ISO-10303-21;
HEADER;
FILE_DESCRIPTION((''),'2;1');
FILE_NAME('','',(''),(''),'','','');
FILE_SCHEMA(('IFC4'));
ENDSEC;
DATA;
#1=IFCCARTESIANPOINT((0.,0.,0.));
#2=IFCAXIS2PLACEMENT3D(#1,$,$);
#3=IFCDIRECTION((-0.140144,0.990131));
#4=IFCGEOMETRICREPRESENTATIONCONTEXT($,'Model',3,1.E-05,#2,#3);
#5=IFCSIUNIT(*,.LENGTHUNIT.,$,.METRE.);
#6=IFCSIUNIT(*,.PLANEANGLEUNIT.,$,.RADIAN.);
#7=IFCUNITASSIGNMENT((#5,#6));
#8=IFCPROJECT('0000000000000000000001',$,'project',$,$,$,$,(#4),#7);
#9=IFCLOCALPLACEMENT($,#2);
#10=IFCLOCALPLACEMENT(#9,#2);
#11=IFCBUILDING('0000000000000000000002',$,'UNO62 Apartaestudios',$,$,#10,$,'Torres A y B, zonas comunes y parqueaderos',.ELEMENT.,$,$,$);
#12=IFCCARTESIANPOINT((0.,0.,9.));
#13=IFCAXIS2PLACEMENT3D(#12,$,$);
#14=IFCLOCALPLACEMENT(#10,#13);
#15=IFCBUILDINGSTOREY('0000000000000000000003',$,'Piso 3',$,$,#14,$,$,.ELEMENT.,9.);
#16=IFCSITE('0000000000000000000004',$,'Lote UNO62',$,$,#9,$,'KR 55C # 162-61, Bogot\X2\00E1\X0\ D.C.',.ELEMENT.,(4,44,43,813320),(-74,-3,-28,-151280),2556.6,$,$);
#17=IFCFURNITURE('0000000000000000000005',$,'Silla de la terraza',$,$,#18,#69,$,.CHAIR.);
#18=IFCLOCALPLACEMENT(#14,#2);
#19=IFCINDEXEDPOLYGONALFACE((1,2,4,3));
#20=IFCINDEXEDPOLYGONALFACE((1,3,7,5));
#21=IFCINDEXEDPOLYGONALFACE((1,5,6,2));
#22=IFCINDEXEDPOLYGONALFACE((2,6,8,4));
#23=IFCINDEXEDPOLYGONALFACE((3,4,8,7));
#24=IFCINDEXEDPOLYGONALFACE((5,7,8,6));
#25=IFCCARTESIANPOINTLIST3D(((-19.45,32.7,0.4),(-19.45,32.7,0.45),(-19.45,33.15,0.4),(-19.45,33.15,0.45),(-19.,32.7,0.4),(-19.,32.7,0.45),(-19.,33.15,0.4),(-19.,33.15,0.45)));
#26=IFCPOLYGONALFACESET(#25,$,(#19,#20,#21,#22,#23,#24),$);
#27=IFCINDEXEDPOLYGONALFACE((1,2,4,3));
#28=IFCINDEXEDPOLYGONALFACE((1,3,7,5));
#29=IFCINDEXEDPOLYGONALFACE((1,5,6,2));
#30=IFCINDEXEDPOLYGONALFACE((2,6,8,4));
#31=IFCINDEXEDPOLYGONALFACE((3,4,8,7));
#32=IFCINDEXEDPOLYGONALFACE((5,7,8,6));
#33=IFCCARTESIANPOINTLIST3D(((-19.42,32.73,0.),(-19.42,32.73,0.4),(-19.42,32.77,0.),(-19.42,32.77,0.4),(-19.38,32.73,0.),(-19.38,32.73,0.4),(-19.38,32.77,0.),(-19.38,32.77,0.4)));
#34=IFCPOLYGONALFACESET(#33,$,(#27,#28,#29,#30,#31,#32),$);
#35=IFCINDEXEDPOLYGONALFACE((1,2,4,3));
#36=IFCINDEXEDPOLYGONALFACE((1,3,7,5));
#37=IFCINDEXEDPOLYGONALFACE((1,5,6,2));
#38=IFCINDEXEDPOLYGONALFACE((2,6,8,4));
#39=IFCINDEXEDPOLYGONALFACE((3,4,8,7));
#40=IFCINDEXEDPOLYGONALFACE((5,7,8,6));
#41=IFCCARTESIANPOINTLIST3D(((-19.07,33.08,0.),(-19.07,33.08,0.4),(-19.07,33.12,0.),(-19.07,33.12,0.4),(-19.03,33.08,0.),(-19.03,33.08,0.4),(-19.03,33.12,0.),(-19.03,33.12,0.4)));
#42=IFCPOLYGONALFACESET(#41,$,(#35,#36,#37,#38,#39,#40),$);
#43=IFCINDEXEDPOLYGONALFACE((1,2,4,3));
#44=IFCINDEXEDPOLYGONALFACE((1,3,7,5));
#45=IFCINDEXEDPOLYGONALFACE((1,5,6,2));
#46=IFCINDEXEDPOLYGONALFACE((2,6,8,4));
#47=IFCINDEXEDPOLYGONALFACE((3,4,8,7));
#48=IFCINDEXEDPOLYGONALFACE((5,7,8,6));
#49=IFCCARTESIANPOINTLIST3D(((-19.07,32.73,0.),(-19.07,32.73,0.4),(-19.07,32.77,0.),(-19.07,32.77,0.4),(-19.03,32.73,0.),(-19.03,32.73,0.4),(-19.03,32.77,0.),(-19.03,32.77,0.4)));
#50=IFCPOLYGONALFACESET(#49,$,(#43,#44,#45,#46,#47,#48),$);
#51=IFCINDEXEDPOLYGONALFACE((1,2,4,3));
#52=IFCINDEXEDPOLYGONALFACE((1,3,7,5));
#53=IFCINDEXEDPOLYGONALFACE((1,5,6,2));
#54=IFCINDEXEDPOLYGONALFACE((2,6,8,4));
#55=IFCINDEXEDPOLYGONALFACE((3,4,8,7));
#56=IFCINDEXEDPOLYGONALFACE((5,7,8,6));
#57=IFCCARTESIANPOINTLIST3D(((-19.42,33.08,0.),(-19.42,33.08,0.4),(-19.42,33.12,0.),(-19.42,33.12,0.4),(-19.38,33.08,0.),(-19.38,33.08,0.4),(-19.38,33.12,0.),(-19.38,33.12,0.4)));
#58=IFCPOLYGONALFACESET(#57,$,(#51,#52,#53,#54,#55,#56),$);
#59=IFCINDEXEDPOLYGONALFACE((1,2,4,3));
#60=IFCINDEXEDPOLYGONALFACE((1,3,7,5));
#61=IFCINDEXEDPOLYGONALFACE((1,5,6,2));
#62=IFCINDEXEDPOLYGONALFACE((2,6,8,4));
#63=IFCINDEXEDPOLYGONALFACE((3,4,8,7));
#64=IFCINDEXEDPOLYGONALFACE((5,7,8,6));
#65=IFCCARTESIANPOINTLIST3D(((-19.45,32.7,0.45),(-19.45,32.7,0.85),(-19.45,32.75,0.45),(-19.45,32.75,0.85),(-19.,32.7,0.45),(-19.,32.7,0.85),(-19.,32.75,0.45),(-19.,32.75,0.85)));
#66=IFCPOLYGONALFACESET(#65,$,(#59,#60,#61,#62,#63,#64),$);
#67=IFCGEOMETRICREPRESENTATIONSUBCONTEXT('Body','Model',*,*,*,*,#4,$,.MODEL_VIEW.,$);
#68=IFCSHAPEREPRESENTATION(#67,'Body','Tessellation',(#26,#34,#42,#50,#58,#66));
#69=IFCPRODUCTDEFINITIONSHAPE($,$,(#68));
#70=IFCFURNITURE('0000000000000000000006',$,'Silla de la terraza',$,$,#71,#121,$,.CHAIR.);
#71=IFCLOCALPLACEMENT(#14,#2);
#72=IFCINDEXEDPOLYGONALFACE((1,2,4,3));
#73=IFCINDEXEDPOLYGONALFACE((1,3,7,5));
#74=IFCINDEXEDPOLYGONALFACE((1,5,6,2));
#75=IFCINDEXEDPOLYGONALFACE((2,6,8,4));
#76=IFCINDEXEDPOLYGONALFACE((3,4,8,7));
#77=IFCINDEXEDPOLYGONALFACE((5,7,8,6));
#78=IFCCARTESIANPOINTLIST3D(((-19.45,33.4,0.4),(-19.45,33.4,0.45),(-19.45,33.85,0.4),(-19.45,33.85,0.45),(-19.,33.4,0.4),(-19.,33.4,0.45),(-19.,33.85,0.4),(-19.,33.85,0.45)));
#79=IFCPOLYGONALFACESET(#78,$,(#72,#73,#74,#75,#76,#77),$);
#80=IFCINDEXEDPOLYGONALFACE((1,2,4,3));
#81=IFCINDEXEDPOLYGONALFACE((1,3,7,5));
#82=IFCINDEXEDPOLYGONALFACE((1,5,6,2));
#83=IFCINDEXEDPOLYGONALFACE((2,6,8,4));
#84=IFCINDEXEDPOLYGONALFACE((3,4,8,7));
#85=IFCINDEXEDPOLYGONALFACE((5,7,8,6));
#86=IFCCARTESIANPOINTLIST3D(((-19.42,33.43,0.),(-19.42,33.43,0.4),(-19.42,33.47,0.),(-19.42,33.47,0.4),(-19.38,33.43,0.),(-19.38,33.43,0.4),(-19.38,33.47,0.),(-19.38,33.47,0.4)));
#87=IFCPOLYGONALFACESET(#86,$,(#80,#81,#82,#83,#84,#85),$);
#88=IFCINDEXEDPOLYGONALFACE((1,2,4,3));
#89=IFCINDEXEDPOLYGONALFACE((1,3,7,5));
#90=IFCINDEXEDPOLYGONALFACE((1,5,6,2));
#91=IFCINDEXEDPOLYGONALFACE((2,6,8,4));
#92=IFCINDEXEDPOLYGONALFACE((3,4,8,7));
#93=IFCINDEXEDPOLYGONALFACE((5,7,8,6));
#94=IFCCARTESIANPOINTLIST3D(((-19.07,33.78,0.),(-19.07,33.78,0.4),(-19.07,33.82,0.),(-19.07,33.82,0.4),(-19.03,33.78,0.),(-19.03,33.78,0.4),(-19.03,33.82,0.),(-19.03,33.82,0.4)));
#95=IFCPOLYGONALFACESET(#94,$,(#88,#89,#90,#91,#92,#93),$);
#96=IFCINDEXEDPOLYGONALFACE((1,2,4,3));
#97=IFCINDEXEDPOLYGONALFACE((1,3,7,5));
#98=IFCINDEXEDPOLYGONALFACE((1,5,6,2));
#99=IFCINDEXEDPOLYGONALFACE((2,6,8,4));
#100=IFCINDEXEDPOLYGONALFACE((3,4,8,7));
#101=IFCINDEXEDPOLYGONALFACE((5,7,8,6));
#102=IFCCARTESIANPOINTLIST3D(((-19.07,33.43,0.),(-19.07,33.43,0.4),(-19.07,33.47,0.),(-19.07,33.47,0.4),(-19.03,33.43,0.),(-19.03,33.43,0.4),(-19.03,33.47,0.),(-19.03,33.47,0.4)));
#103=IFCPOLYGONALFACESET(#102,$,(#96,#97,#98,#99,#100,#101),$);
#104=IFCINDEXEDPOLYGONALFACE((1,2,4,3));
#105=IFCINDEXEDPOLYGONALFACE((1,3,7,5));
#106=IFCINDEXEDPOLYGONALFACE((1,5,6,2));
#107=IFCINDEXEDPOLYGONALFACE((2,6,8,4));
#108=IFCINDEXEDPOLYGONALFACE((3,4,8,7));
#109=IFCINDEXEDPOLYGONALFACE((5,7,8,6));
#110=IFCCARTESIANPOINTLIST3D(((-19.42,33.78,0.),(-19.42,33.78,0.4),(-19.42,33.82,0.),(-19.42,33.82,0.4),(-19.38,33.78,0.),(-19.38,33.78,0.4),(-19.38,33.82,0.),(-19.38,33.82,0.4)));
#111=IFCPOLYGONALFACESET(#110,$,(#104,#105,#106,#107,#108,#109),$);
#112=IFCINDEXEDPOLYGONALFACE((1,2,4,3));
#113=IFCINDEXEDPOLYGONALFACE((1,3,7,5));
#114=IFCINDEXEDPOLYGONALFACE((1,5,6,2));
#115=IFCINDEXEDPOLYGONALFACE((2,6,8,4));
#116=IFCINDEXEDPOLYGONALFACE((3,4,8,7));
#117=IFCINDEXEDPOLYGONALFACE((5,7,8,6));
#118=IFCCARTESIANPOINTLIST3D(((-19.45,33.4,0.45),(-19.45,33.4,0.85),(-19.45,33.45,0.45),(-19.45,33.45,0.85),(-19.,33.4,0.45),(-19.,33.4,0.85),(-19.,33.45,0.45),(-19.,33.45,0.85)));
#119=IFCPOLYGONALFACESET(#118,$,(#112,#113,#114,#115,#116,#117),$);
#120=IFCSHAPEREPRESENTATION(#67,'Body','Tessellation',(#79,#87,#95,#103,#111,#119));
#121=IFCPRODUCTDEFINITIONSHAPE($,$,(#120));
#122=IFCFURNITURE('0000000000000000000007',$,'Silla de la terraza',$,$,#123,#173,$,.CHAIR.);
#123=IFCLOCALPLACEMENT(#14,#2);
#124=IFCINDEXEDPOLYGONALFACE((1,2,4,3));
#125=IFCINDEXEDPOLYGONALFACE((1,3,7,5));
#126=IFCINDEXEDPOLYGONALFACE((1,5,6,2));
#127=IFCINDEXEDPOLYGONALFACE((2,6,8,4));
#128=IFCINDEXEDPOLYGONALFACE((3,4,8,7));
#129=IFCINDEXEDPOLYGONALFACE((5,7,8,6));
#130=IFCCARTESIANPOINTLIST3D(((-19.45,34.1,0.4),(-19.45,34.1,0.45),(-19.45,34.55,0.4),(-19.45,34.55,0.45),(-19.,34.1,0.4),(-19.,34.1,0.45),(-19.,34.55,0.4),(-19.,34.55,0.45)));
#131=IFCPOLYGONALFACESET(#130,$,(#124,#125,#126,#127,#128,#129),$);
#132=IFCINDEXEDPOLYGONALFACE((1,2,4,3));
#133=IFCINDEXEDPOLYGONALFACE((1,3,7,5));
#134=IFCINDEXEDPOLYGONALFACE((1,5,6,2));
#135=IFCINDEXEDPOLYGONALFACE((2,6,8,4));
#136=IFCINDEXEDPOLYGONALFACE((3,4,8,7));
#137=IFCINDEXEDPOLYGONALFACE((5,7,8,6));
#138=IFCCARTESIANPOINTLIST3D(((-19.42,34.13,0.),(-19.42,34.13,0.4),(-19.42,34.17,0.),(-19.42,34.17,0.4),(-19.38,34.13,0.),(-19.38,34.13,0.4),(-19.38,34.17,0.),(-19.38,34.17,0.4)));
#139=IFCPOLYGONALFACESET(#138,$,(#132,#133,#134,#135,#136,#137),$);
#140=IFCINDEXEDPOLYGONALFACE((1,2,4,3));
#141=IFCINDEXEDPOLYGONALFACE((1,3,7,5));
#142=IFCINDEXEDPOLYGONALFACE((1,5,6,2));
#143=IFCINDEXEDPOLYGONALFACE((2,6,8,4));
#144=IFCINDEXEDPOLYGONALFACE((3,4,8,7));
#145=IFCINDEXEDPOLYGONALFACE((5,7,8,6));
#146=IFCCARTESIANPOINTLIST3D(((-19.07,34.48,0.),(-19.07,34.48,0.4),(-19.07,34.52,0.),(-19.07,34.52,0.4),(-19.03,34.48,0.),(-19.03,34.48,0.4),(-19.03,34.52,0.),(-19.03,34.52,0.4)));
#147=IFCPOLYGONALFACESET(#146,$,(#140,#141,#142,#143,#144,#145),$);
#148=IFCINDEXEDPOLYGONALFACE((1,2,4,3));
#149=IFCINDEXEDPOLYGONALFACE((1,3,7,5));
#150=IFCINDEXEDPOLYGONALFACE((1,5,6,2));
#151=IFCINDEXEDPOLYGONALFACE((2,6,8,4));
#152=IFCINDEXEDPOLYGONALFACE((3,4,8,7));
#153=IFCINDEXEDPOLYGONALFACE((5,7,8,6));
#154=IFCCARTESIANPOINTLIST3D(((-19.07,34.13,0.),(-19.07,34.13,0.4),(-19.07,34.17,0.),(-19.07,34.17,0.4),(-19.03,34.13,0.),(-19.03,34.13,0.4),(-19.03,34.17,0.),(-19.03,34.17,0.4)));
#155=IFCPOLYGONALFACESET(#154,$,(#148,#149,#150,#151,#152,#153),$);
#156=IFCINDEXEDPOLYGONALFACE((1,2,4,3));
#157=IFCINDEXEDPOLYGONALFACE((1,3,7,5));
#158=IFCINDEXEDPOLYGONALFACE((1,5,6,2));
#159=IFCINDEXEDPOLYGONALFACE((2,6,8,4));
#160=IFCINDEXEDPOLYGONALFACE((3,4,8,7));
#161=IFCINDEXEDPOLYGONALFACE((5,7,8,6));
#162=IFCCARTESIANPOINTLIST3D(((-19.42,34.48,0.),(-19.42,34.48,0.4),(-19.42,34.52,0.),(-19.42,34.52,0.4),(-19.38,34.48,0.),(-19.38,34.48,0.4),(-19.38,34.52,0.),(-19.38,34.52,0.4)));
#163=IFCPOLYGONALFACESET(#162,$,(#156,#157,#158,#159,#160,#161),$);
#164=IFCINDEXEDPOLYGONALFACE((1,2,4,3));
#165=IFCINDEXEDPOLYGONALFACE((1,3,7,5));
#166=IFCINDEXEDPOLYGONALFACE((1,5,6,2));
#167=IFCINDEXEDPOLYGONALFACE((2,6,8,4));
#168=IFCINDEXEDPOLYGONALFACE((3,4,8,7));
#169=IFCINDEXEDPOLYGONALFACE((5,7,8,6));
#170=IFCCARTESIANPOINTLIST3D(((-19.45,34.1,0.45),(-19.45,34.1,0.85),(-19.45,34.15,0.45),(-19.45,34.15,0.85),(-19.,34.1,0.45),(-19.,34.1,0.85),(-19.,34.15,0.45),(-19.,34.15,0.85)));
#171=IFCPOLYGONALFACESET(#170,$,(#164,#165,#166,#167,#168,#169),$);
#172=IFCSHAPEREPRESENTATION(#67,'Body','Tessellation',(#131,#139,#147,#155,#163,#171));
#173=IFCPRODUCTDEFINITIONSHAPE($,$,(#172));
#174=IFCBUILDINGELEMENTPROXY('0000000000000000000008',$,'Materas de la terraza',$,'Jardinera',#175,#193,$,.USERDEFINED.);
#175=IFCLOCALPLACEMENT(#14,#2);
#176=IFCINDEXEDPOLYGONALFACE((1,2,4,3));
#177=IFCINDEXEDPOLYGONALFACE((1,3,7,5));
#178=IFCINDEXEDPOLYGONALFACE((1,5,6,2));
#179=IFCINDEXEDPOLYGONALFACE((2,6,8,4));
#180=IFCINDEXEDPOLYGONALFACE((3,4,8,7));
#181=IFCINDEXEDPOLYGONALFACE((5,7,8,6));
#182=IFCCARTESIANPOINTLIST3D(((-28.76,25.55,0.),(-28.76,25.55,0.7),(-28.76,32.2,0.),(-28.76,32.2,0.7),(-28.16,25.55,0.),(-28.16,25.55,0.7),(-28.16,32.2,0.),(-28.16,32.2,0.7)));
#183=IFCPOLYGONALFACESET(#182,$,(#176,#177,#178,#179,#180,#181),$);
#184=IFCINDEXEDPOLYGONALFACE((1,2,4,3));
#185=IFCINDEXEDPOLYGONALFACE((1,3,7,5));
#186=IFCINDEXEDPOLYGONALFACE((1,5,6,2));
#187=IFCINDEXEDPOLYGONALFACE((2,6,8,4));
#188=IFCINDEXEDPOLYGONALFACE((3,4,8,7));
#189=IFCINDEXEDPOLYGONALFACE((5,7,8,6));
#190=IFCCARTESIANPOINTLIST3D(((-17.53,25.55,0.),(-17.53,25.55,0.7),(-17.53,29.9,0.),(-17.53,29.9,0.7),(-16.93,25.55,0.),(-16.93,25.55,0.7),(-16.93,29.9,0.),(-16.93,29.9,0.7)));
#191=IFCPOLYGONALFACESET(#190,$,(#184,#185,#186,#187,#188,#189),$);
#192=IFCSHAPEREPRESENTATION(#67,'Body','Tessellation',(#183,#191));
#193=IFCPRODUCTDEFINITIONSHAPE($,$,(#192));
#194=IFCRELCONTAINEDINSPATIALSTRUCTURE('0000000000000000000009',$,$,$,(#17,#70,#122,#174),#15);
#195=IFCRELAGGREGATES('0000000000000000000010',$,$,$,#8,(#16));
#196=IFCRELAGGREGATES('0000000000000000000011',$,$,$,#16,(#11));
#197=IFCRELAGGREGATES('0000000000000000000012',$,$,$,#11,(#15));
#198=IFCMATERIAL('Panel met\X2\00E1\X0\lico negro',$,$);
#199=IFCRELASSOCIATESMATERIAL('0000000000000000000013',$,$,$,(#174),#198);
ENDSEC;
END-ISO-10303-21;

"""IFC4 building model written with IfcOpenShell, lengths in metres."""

from ifc_helpers import new_model, si_unit, direction, frame, frame_2d, origin, place, context, subcontext, project, spatial, rectangle, extrude, material, element, save


model = new_model("IFC4")

# Units and contexts
model_context = context("Model", 3, precision=1e-05, world=origin(), true_north=direction((-0.140144, 0.990131)))
body_context = subcontext(model_context, "Body", "Model", "MODEL_VIEW")
ifc_project = project(units=[si_unit("LENGTHUNIT", "METRE"), si_unit("PLANEANGLEUNIT", "RADIAN")], contexts=[model_context])

# Site, building, storey
site_placement = place(None, origin())
site = spatial("IfcSite", under=ifc_project, at=site_placement, Name="Lote UNO62", LongName="KR 55C # 162-61, Bogotá D.C.", CompositionType="ELEMENT", RefLatitude=(4, 44, 43, 813320), RefLongitude=(-74, -3, -28, -151280), RefElevation=2556.6)
building_placement = place(site_placement, origin())
building = spatial("IfcBuilding", under=site, at=building_placement, Name="UNO62 Apartaestudios", LongName="Torres A y B, zonas comunes y parqueaderos", CompositionType="ELEMENT")
storey_placement = place(building_placement, frame((0.0, 0.0, 9.0)))
storey = spatial("IfcBuildingStorey", under=building, at=storey_placement, Name="Piso 3", CompositionType="ELEMENT", Elevation=9.0)

# Shared definitions
ifc_material_1 = material(Name="Panel metálico negro")

# Furniture
furniture_1_placement = place(storey_placement, origin())
element("IfcFurniture", 1, at=furniture_1_placement, inside=storey, Name="Silla de la terraza", PredefinedType="CHAIR", context=body_context, shape_type="SweptSolid", body=[
    extrude(rectangle(XDim=0.45, YDim=0.45, at=frame_2d((-19.225, 32.925))), frame((0.0, 0.0, 0.4)), (0.0, 0.0, 1.0), 0.05),
    extrude(rectangle(XDim=0.04, YDim=0.04, at=frame_2d((-19.4, 32.75))), origin(), (0.0, 0.0, 1.0), 0.4),
    extrude(rectangle(XDim=0.04, YDim=0.04, at=frame_2d((-19.05, 33.1))), origin(), (0.0, 0.0, 1.0), 0.4),
    extrude(rectangle(XDim=0.04, YDim=0.04, at=frame_2d((-19.05, 32.75))), origin(), (0.0, 0.0, 1.0), 0.4),
    extrude(rectangle(XDim=0.04, YDim=0.04, at=frame_2d((-19.4, 33.1))), origin(), (0.0, 0.0, 1.0), 0.4),
    extrude(rectangle(XDim=0.45, YDim=0.05, at=frame_2d((-19.225, 32.725))), frame((0.0, 0.0, 0.45)), (0.0, 0.0, 1.0), 0.4),
])
furniture_2_placement = place(storey_placement, origin())
element("IfcFurniture", 2, at=furniture_2_placement, inside=storey, Name="Silla de la terraza", PredefinedType="CHAIR", context=body_context, shape_type="SweptSolid", body=[
    extrude(rectangle(XDim=0.45, YDim=0.45, at=frame_2d((-19.225, 33.625))), frame((0.0, 0.0, 0.4)), (0.0, 0.0, 1.0), 0.05),
    extrude(rectangle(XDim=0.04, YDim=0.04, at=frame_2d((-19.4, 33.45))), origin(), (0.0, 0.0, 1.0), 0.4),
    extrude(rectangle(XDim=0.04, YDim=0.04, at=frame_2d((-19.05, 33.8))), origin(), (0.0, 0.0, 1.0), 0.4),
    extrude(rectangle(XDim=0.04, YDim=0.04, at=frame_2d((-19.05, 33.45))), origin(), (0.0, 0.0, 1.0), 0.4),
    extrude(rectangle(XDim=0.04, YDim=0.04, at=frame_2d((-19.4, 33.8))), origin(), (0.0, 0.0, 1.0), 0.4),
    extrude(rectangle(XDim=0.45, YDim=0.05, at=frame_2d((-19.225, 33.425))), frame((0.0, 0.0, 0.45)), (0.0, 0.0, 1.0), 0.4),
])
furniture_3_placement = place(storey_placement, origin())
element("IfcFurniture", 3, at=furniture_3_placement, inside=storey, Name="Silla de la terraza", PredefinedType="CHAIR", context=body_context, shape_type="SweptSolid", body=[
    extrude(rectangle(XDim=0.45, YDim=0.45, at=frame_2d((-19.225, 34.325))), frame((0.0, 0.0, 0.4)), (0.0, 0.0, 1.0), 0.05),
    extrude(rectangle(XDim=0.04, YDim=0.04, at=frame_2d((-19.4, 34.15))), origin(), (0.0, 0.0, 1.0), 0.4),
    extrude(rectangle(XDim=0.04, YDim=0.04, at=frame_2d((-19.05, 34.5))), origin(), (0.0, 0.0, 1.0), 0.4),
    extrude(rectangle(XDim=0.04, YDim=0.04, at=frame_2d((-19.05, 34.15))), origin(), (0.0, 0.0, 1.0), 0.4),
    extrude(rectangle(XDim=0.04, YDim=0.04, at=frame_2d((-19.4, 34.5))), origin(), (0.0, 0.0, 1.0), 0.4),
    extrude(rectangle(XDim=0.45, YDim=0.05, at=frame_2d((-19.225, 34.125))), frame((0.0, 0.0, 0.45)), (0.0, 0.0, 1.0), 0.4),
])

# Building element proxy
proxy_placement = place(storey_placement, origin())
element("IfcBuildingElementProxy", 4, at=proxy_placement, inside=storey, material=ifc_material_1, Name="Materas de la terraza", ObjectType="Jardinera", PredefinedType="USERDEFINED", context=body_context, shape_type="SweptSolid", body=[
    extrude(rectangle(XDim=0.6, YDim=6.65, at=frame_2d((-28.46, 28.875))), origin(), (0.0, 0.0, 1.0), 0.7),
    extrude(rectangle(XDim=0.6, YDim=4.35, at=frame_2d((-17.23, 27.725))), origin(), (0.0, 0.0, 1.0), 0.7),
])

save(model, "model.ifc")
